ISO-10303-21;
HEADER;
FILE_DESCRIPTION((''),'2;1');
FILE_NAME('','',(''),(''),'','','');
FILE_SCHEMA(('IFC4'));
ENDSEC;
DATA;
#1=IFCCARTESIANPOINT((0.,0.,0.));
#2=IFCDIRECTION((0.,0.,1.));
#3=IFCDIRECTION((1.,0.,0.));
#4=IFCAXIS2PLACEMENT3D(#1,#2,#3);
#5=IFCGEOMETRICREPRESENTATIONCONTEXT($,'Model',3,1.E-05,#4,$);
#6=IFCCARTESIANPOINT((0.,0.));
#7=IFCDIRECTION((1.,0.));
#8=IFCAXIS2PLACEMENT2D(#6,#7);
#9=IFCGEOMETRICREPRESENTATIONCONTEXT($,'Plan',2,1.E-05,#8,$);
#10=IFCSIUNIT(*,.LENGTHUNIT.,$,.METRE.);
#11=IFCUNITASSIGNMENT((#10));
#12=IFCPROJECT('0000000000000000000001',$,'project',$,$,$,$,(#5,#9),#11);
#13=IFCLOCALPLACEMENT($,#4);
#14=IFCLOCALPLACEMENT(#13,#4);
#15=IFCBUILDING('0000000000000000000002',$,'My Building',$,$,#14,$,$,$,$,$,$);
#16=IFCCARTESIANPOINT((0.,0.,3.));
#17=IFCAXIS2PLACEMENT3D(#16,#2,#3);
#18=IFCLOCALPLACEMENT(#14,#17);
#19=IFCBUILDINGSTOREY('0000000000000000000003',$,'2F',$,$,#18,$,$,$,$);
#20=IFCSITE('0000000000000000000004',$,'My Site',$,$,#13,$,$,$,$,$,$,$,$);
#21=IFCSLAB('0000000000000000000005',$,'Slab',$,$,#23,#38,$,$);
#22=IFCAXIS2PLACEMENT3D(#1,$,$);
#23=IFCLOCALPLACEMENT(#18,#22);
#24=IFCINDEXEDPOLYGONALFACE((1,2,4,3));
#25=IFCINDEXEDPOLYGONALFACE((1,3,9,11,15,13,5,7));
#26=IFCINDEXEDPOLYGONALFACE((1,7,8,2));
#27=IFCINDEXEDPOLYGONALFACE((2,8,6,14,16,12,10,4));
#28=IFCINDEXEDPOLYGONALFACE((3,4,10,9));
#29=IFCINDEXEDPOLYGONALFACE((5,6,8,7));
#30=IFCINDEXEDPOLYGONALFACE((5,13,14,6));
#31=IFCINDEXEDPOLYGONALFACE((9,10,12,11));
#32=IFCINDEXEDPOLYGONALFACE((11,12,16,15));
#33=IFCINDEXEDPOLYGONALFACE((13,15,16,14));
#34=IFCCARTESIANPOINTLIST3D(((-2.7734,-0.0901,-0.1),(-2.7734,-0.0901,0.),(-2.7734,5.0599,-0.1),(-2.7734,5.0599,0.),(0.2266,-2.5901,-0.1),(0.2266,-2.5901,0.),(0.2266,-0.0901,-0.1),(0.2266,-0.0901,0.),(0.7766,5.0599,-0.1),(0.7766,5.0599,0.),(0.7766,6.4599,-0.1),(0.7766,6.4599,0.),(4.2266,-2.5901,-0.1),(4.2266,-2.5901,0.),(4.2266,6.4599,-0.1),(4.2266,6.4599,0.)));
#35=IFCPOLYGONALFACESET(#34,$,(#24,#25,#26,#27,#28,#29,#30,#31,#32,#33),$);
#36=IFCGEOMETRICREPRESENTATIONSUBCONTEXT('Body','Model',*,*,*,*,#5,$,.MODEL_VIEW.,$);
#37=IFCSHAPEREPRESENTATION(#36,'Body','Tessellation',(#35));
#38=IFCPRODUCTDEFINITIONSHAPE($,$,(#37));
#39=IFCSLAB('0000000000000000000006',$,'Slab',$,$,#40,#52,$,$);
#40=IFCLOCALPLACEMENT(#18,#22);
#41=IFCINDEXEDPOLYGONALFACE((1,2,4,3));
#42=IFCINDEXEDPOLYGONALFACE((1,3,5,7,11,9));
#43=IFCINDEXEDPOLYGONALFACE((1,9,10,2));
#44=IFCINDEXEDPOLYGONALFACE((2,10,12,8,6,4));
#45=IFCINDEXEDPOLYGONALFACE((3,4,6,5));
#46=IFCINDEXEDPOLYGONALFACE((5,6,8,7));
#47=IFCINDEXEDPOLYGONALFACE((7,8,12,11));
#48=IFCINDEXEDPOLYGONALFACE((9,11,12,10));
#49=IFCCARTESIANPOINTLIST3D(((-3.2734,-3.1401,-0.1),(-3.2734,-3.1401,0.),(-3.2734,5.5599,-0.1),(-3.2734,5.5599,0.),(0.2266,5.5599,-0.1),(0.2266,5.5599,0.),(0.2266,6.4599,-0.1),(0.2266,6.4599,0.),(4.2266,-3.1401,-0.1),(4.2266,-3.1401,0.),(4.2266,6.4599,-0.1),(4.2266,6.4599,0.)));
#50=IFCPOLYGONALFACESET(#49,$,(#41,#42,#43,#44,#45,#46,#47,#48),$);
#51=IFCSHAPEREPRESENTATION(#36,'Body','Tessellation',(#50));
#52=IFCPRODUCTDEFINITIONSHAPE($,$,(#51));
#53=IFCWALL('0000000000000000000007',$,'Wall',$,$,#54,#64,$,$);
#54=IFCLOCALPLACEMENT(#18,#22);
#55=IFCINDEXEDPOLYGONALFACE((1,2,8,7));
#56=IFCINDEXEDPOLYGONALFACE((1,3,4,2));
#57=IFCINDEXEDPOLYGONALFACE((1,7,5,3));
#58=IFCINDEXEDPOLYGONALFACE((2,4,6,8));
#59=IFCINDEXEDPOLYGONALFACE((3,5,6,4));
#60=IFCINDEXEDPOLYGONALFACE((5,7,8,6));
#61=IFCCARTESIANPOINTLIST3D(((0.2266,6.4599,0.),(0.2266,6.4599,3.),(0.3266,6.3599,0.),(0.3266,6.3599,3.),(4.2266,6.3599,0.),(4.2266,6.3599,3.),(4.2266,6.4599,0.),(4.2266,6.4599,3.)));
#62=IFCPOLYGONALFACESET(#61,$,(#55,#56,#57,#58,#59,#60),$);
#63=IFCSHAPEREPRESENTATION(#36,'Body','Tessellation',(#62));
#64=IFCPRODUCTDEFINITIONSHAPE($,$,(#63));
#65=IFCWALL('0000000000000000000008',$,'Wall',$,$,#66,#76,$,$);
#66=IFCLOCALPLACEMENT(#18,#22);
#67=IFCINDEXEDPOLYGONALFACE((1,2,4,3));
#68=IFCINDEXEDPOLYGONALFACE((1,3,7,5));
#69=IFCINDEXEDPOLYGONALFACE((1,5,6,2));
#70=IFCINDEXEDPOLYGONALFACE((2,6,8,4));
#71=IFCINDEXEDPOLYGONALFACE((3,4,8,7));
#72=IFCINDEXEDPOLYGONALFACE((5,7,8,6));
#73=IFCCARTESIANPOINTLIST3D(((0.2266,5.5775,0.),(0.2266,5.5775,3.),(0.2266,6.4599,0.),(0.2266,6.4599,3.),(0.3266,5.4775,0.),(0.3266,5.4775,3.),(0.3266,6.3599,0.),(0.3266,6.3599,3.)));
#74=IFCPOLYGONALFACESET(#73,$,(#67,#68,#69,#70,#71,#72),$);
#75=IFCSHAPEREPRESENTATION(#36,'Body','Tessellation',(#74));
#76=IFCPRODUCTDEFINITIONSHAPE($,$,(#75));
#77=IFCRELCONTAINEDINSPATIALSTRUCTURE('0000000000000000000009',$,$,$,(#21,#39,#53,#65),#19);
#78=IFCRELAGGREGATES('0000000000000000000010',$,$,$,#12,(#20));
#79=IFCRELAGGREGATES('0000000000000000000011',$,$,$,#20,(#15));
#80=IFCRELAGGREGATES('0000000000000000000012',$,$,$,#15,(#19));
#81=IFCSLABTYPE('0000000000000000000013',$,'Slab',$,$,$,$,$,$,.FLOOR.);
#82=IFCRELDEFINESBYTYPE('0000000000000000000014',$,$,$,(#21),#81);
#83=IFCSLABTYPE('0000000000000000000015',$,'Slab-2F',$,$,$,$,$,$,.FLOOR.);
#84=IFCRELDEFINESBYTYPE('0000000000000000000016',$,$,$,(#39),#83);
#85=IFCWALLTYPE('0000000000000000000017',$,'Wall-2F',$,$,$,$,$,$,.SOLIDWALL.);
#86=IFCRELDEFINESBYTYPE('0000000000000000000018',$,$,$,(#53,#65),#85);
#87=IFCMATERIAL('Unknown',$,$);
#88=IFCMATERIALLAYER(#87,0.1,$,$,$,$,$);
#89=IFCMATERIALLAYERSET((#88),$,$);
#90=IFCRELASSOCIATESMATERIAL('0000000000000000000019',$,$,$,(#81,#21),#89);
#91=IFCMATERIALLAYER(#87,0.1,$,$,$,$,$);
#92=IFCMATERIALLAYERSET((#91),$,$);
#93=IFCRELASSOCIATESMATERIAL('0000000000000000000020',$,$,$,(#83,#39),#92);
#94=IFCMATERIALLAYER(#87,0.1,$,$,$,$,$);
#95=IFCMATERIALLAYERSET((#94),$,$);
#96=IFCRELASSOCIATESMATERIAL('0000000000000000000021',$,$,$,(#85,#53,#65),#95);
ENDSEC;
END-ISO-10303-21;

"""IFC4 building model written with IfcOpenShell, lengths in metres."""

from ifc_helpers import new_model, si_unit, frame, origin_with_axes, origin_2d_with_axis, place, context, subcontext, project, spatial, line, indexed_curve, outline, extrude, material, layer, layer_set, layer_usage, type_object, element, save


model = new_model("IFC4")

# Units and contexts
model_context = context("Model", 3, precision=1e-05, world=origin_with_axes())
plan_context = context("Plan", 2, precision=1e-05, world=origin_2d_with_axis())
body_context_1 = subcontext(model_context, "Body", "Model", "MODEL_VIEW")
ifc_project = project(units=[si_unit("LENGTHUNIT", "METRE")], contexts=[model_context, plan_context])

# Site, building, storey
site_placement = place(None, origin_with_axes())
site = spatial("IfcSite", under=ifc_project, at=site_placement, Name="My Site")
building_placement = place(site_placement, origin_with_axes())
building = spatial("IfcBuilding", under=site, at=building_placement, Name="My Building")
storey_placement = place(building_placement, frame((0.0, 0.0, 3.0), z_axis=(0.0, 0.0, 1.0), x_axis=(1.0, 0.0, 0.0)))
storey = spatial("IfcBuildingStorey", under=building, at=storey_placement, Name="2F")

# Slabs
ifc_material = material(Name="Unknown")
ifc_layer_1 = layer(ifc_material, 0.1)
ifc_layer_set_1 = layer_set([ifc_layer_1])
ifc_layer_usage_1 = layer_usage(ifc_layer_set_1, "AXIS3", "POSITIVE", -0.1)
slab_type_1 = type_object("IfcSlabType", Name="Slab", PredefinedType="FLOOR", material=ifc_layer_set_1)
slab_1_placement = place(storey_placement, frame((4.2266, -2.5901, 0.0), z_axis=(0.0, 0.0, 1.0), x_axis=(1.0, 0.0, 0.0)))
element("IfcSlab", 1, at=slab_1_placement, inside=storey, type_object=slab_type_1, material=ifc_layer_usage_1, Name="Slab", context=body_context_1, shape_type="SweptSolid", body=[
    extrude(outline(indexed_curve([(0.0, 0.0), (0.0, 9.05), (-3.45, 9.05), (-3.45, 7.65), (-7.0, 7.65), (-7.0, 2.5), (-4.0, 2.5), (-4.0, 0.0), (0.0, 0.0)])), frame((0.0, 0.0, -0.1), z_axis=(0.0, 0.0, 1.0), x_axis=(1.0, 0.0, 0.0)), (0.0, 0.0, 1.0), 0.1),
])
ifc_layer_2 = layer(ifc_material, 0.1)
ifc_layer_set_2 = layer_set([ifc_layer_2])
ifc_layer_usage_2 = layer_usage(ifc_layer_set_2, "AXIS3", "POSITIVE", -0.1)
slab_type_2 = type_object("IfcSlabType", Name="Slab-2F", PredefinedType="FLOOR", material=ifc_layer_set_2)
slab_2_placement = place(storey_placement, frame((4.2266, 6.4599, 0.0), z_axis=(0.0, 0.0, 1.0), x_axis=(1.0, 0.0, 0.0)))
element("IfcSlab", 2, at=slab_2_placement, inside=storey, type_object=slab_type_2, material=ifc_layer_usage_2, Name="Slab", context=body_context_1, shape_type="SweptSolid", body=[
    extrude(outline(indexed_curve([(0.0, 0.0), (-4.0, 0.0), (-4.0, -0.9), (-7.5, -0.9), (-7.5, -9.6), (0.0, -9.6), (0.0, 0.0)])), frame((0.0, 0.0, -0.1), z_axis=(0.0, 0.0, 1.0), x_axis=(1.0, 0.0, 0.0)), (0.0, 0.0, 1.0), 0.1),
])

# Walls
ifc_layer_3 = layer(ifc_material, 0.1)
ifc_layer_set_3 = layer_set([ifc_layer_3])
ifc_layer_usage_3 = layer_usage(ifc_layer_set_3, "AXIS2", "POSITIVE", 0.0)
wall_type_1 = type_object("IfcWallType", Name="Wall-2F", PredefinedType="SOLIDWALL", material=ifc_layer_set_3)
wall_1_placement = place(storey_placement, frame((4.2266, 6.4599, 0.0), z_axis=(0.0, 0.0, 1.0), x_axis=(-1.0, 0.0, 0.0)))
element("IfcWall", 3, at=wall_1_placement, inside=storey, type_object=wall_type_1, material=ifc_layer_usage_3, Name="Wall", context=body_context_1, shape_type="SweptSolid", body=[
    extrude(outline(indexed_curve([(0.0, 0.0), (0.0, 0.1), (3.9, 0.1), (4.0, 0.0)], segments=[line(1, 2, 3, 4, 1)])), origin_with_axes(), (0.0, 0.0, 1.0), 3.0),
])
ifc_layer_usage_4 = layer_usage(ifc_layer_set_3, "AXIS2", "POSITIVE", 0.0)
wall_2_placement = place(storey_placement, frame((0.2266, 6.4599, 0.0), z_axis=(0.0, 0.0, 1.0), x_axis=(0.0, -1.0, 0.0)))
element("IfcWall", 4, at=wall_2_placement, inside=storey, type_object=wall_type_1, material=ifc_layer_usage_4, Name="Wall", context=body_context_1, shape_type="SweptSolid", body=[
    extrude(outline(indexed_curve([(0.0, 0.0), (0.1, 0.1), (0.9824, 0.1), (0.8824, 0.0)], segments=[line(1, 2, 3, 4, 1)])), origin_with_axes(), (0.0, 0.0, 1.0), 3.0),
])

save(model, "model.ifc")
